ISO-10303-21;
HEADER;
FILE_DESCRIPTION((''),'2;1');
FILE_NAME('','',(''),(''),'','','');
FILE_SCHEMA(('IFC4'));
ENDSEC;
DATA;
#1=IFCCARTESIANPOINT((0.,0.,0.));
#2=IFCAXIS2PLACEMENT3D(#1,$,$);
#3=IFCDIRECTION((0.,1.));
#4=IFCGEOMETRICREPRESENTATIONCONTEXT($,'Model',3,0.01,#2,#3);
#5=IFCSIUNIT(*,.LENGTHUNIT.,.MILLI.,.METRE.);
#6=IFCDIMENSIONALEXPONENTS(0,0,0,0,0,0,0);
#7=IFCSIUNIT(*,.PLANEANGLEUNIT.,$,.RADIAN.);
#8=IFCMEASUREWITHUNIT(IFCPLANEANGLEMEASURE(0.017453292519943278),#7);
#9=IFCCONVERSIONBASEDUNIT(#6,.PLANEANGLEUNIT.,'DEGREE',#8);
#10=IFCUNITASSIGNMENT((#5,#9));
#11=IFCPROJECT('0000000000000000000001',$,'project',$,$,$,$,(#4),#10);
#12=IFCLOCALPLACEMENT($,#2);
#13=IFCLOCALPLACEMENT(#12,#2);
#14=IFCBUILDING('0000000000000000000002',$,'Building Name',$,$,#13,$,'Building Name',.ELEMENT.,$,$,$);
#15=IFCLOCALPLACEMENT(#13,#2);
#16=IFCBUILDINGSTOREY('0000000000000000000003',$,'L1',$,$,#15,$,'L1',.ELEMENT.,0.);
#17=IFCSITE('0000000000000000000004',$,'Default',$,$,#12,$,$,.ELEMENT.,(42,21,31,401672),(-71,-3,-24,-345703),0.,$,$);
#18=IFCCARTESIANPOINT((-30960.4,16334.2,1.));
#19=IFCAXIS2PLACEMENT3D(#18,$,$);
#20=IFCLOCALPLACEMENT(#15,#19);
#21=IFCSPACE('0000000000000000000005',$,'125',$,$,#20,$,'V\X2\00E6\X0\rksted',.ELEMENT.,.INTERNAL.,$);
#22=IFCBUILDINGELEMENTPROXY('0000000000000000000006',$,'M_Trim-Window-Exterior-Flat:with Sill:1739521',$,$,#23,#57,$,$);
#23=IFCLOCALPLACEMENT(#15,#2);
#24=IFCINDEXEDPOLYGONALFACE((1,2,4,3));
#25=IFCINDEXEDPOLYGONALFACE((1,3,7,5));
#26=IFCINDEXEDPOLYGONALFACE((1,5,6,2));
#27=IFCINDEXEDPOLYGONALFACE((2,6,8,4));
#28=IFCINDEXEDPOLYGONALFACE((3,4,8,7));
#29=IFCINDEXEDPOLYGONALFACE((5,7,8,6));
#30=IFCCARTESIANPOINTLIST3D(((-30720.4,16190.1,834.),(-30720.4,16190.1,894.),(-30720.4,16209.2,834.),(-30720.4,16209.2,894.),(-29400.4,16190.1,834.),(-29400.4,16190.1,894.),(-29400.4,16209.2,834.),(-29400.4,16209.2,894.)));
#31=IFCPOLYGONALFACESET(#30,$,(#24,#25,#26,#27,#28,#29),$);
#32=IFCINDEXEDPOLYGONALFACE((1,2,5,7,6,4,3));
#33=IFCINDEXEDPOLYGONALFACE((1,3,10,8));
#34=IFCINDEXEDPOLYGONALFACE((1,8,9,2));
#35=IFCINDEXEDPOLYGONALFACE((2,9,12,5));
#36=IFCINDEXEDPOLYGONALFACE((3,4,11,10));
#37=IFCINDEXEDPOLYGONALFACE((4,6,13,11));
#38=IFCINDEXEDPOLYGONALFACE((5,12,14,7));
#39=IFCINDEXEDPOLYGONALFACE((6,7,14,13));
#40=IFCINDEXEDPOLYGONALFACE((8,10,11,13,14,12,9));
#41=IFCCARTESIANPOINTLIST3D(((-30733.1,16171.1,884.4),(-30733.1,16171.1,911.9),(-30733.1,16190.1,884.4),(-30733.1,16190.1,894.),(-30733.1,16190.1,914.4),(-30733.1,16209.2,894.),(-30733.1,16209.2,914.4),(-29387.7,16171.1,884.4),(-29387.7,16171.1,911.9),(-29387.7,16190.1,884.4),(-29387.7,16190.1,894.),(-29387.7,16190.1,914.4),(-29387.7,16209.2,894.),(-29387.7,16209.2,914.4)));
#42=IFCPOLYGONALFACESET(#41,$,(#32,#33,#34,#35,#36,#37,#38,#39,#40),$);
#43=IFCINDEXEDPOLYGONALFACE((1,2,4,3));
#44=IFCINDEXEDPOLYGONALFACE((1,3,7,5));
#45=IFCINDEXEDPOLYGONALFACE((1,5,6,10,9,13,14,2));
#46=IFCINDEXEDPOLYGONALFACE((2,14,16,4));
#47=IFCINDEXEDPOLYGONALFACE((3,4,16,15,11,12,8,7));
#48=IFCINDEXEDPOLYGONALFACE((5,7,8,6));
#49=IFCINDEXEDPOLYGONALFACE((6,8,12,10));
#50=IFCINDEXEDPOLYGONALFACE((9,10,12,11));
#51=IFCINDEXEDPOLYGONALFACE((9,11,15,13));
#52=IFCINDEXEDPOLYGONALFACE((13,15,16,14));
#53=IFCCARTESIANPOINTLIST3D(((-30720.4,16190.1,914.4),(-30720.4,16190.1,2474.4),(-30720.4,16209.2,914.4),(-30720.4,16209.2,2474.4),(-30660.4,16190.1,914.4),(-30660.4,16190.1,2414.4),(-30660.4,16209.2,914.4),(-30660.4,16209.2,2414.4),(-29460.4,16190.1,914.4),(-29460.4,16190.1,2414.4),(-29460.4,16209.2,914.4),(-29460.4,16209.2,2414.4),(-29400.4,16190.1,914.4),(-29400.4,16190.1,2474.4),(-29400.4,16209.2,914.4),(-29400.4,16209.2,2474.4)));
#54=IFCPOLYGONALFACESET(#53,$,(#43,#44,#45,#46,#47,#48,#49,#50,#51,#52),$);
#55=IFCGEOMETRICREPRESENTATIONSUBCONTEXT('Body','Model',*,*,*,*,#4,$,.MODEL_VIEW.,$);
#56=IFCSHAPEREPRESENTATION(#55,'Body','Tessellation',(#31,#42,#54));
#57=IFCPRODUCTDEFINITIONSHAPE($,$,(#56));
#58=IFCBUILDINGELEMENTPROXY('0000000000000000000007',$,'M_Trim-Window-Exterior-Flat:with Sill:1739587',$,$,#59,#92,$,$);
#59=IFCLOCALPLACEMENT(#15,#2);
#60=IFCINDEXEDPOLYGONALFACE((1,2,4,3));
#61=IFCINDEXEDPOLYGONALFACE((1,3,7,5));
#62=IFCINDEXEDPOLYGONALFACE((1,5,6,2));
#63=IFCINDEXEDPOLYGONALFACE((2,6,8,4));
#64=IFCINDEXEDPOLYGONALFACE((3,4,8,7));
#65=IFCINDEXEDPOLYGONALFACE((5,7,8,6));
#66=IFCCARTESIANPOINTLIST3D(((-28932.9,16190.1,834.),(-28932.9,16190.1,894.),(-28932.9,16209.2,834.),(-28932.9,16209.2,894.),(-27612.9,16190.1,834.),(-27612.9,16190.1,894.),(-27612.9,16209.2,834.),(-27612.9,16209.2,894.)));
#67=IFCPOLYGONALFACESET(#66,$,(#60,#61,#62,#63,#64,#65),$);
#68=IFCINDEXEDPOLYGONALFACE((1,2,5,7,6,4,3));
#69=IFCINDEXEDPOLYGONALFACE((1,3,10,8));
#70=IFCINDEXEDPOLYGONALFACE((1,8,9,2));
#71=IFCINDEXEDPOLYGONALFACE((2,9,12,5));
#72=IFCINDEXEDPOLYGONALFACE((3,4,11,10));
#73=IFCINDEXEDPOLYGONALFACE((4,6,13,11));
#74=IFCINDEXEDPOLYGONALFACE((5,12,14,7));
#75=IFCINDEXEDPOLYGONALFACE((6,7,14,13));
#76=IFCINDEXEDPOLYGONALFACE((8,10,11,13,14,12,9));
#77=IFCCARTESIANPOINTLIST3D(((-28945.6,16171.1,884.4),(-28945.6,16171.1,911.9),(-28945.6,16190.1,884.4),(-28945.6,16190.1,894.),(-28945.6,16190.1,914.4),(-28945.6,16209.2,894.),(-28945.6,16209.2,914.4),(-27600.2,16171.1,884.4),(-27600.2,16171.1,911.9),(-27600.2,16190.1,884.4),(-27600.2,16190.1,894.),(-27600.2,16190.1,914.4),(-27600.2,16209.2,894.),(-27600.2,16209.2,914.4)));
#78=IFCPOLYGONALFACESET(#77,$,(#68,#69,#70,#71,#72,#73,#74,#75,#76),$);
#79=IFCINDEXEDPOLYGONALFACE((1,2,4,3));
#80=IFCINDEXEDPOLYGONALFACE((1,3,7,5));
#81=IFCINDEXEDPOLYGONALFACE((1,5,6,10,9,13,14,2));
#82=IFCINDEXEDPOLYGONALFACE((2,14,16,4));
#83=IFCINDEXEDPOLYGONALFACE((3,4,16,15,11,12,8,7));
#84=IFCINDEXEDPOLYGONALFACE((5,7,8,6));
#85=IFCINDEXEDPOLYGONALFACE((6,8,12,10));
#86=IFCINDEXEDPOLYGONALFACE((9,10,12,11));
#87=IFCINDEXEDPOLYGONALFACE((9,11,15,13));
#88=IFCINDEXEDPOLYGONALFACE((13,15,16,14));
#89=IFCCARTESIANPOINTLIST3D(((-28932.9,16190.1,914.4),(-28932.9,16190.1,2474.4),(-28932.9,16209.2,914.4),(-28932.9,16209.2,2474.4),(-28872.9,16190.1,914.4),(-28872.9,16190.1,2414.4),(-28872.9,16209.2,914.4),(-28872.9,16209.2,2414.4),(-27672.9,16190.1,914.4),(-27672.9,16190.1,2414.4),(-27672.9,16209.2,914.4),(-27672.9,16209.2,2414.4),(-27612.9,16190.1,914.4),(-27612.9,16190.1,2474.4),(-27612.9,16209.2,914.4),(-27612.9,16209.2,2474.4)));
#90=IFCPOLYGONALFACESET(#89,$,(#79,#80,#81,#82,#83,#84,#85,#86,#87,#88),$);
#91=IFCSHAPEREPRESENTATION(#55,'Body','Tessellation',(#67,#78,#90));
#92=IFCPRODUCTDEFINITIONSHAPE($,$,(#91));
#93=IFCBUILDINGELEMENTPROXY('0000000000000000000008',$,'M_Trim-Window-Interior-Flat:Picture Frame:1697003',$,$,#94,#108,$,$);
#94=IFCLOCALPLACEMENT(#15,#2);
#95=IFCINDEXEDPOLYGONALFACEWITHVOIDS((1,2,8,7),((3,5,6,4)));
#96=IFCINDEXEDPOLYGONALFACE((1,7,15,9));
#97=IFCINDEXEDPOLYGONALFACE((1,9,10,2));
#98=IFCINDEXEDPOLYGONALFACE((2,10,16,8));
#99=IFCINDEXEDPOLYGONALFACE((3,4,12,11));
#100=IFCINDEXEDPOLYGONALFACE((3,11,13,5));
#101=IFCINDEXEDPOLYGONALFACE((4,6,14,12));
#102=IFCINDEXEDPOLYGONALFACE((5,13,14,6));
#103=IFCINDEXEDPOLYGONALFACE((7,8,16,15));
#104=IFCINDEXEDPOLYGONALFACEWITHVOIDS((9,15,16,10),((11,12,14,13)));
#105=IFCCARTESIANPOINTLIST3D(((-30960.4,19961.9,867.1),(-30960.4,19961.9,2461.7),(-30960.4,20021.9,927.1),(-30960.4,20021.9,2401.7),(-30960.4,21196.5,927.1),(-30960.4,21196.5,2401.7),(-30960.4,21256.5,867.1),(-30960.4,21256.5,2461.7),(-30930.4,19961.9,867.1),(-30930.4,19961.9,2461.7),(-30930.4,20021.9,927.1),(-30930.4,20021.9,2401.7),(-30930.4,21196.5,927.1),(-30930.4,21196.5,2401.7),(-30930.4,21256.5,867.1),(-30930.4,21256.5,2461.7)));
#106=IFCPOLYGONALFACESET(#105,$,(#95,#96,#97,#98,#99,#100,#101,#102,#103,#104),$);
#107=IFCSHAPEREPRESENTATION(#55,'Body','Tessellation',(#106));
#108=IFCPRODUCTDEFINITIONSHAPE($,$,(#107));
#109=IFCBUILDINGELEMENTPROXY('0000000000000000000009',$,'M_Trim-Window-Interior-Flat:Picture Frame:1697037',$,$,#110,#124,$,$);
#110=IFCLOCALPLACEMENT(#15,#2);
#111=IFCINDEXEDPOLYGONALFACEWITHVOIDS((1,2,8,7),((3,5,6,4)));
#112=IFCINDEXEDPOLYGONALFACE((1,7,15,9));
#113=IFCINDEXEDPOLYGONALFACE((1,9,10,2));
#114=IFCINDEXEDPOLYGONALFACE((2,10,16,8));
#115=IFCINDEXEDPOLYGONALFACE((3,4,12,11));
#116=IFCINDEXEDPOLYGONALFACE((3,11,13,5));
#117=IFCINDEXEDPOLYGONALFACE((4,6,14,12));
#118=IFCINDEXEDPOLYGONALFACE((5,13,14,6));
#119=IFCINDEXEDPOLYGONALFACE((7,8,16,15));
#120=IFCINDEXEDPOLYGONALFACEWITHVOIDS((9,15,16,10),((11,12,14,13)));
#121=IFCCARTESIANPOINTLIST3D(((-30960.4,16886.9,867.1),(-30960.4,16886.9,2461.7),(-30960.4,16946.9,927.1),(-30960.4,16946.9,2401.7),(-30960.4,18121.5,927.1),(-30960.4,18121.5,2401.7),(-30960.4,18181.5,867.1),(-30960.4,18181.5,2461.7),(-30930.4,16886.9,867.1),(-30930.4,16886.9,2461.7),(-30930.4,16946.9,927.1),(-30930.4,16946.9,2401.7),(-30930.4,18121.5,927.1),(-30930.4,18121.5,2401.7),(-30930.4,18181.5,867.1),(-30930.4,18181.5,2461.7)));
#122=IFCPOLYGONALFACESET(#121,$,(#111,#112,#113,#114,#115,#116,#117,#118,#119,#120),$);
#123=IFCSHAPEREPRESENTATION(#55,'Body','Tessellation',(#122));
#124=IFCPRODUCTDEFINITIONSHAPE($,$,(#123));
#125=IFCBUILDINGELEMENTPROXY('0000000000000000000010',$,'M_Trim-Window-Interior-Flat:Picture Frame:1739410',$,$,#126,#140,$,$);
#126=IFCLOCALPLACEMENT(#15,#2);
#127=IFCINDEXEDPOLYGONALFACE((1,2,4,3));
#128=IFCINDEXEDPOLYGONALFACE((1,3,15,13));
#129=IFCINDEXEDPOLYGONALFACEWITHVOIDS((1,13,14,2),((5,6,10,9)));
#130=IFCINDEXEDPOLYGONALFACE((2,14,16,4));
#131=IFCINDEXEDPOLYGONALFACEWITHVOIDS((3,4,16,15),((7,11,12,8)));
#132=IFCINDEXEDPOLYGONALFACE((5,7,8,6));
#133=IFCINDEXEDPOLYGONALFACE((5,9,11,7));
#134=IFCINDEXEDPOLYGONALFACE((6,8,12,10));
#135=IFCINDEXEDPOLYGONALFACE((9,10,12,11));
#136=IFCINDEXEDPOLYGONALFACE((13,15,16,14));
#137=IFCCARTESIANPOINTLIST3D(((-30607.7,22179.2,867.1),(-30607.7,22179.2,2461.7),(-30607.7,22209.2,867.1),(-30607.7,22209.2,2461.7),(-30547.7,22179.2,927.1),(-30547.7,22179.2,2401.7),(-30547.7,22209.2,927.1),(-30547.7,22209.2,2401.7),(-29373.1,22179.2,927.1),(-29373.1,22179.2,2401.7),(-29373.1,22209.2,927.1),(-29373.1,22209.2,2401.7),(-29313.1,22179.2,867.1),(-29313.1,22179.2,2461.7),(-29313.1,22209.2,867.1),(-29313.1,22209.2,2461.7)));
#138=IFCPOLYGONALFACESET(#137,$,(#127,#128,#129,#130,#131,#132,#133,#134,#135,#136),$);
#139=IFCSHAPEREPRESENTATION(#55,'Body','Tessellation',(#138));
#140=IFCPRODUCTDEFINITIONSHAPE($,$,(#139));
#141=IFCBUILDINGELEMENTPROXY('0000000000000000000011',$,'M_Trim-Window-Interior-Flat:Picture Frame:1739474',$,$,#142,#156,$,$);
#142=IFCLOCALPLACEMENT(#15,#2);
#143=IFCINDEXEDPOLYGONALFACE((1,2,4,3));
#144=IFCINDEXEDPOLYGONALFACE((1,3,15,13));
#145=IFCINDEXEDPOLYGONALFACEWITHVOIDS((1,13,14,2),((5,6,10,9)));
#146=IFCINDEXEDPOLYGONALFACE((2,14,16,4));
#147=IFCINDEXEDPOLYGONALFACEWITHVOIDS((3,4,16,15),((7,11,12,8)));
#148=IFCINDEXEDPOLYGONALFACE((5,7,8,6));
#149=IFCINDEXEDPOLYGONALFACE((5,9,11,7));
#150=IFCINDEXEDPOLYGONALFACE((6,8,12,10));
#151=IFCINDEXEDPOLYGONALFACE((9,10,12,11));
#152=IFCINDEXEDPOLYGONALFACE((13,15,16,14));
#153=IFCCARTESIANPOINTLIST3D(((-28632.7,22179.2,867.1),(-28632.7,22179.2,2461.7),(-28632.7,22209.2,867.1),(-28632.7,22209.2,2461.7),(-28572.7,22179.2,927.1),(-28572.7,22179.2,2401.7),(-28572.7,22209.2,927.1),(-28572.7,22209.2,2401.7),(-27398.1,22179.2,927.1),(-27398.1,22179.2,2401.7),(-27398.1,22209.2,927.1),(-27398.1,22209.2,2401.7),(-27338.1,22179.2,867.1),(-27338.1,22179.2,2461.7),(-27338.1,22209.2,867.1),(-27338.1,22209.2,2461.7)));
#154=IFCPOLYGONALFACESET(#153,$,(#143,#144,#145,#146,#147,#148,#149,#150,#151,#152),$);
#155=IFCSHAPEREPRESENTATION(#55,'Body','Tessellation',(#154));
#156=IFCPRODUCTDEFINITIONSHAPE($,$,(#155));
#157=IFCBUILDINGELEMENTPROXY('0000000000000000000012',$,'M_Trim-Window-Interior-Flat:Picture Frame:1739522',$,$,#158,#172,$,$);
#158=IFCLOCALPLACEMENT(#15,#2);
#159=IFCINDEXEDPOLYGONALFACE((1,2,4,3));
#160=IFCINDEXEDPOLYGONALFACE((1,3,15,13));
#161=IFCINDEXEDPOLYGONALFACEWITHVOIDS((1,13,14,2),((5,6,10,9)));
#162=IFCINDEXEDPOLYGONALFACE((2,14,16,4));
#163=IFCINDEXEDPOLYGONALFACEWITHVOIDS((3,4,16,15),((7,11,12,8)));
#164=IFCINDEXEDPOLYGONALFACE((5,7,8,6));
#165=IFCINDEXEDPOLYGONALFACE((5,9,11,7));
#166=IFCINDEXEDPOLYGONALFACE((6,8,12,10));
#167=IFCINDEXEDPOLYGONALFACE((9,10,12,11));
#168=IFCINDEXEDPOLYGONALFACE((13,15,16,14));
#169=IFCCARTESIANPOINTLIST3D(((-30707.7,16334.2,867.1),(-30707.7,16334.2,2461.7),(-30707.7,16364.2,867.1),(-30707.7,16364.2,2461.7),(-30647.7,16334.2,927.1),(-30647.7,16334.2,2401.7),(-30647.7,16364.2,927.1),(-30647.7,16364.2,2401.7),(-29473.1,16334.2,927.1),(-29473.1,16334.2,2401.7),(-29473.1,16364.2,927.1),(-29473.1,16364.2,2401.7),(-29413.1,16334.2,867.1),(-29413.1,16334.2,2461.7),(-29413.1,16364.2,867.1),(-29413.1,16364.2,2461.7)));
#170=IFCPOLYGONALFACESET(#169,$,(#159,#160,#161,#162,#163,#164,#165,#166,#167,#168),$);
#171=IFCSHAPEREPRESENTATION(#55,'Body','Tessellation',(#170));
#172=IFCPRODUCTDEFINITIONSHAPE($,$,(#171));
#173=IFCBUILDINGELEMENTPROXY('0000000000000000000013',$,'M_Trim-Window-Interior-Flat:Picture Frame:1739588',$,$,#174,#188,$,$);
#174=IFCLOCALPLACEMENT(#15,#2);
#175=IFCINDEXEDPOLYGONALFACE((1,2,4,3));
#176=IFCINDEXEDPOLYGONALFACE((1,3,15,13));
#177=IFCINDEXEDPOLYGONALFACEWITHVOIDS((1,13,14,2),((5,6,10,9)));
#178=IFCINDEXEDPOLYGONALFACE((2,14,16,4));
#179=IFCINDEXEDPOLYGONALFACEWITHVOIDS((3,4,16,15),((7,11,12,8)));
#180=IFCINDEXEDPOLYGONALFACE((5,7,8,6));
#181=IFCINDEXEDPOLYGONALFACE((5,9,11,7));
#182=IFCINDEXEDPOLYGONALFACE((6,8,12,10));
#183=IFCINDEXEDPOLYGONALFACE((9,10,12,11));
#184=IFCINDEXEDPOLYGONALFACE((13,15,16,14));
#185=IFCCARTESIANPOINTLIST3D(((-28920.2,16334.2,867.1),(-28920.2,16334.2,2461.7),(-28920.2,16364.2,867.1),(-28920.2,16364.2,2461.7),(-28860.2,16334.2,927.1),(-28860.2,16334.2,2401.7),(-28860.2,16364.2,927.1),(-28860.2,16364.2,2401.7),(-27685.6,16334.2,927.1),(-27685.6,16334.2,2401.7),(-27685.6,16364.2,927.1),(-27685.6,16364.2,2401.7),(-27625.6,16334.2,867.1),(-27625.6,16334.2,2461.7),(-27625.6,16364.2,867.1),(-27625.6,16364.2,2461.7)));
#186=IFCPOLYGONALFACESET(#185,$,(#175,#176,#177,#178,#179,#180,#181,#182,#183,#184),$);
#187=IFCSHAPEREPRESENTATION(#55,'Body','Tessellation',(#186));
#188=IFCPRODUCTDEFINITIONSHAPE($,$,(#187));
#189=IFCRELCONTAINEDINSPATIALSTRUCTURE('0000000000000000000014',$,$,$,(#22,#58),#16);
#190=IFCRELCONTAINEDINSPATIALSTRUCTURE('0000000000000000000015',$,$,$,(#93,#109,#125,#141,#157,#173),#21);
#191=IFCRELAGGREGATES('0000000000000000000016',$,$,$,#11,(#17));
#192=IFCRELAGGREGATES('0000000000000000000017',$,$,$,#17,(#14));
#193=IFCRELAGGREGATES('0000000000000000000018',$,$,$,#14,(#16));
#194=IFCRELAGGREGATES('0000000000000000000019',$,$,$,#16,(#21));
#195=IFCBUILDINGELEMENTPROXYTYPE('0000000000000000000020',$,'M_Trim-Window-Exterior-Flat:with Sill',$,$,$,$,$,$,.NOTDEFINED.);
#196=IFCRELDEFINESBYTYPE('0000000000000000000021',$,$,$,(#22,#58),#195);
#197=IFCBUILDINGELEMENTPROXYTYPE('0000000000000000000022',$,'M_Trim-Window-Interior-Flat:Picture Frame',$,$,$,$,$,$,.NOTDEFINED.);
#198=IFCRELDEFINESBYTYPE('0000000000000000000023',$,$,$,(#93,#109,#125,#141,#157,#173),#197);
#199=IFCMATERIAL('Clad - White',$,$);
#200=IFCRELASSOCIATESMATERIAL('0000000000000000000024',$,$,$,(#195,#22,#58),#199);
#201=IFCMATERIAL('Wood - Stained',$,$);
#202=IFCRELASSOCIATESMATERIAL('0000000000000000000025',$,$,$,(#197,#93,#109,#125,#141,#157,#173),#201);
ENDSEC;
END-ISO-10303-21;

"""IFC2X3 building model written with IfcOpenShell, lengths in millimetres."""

from ifc_helpers import new_model, entity, si_unit, converted_unit, direction, frame, frame_2d, origin, place, context, subcontext, project, spatial, polyline, rectangle, outline, extrude, source, transform, mapped, material, type_object, type_shapes, element, save


model = new_model("IFC2X3")

# Units and contexts
model_context = context("Model", 3, precision=0.01, world=origin(), true_north=direction((0.0, 1.0)))
body_context = subcontext(model_context, "Body", "Model", "MODEL_VIEW")
ifc_project = project(units=[si_unit("LENGTHUNIT", "METRE", prefix="MILLI"), converted_unit("PLANEANGLEUNIT", "DEGREE", entity("IfcPlaneAngleMeasure", 0.017453292519943278), si_unit("PLANEANGLEUNIT", "RADIAN"), dimensions=[0, 0, 0, 0, 0, 0, 0])], contexts=[model_context])

# Site, building, storey
site_placement = place(None, origin())
site = spatial("IfcSite", under=ifc_project, at=site_placement, Name="Default", CompositionType="ELEMENT", RefLatitude=(42, 21, 31, 401672), RefLongitude=(-71, -3, -24, -345703), RefElevation=0.0)
building_placement = place(site_placement, origin())
building = spatial("IfcBuilding", under=site, at=building_placement, Name="Building Name", LongName="Building Name", CompositionType="ELEMENT")
storey_placement = place(building_placement, origin())
storey = spatial("IfcBuildingStorey", under=building, at=storey_placement, Name="L1", LongName="L1", CompositionType="ELEMENT", Elevation=0.0)

# Shared definitions
ifc_material_1 = material(Name="Wood - Stained")

# Building element proxies
ifc_material_2 = material(Name="Clad - White")
building_element_proxy_type_1 = type_object("IfcBuildingElementProxyType", Name="M_Trim-Window-Exterior-Flat:with Sill", PredefinedType="NOTDEFINED", material=ifc_material_2)
shared_shape_1 = source(origin(), body_context, "Body", "SweptSolid", [
    extrude(rectangle(XDim=1320.0, YDim=60.0, at=frame_2d((0.0, 0.0), x_axis=(1.0, 0.0))), frame((0.0, -1550.4, 0.0), z_axis=(0.0, 0.0, 1.0), x_axis=(-1.0, 0.0, 0.0)), (0.0, 0.0, 1.0), 19.0),
    extrude(outline(polyline([(-19.0, -15.2), (0.0, -15.2), (0.0, -5.7), (19.0, -5.7), (19.0, 14.8), (0.0, 14.8), (-19.0, 12.3), (-19.0, -15.2)])), frame((-672.7, -1514.8, 19.0), z_axis=(1.0, 0.0, 0.0), x_axis=(0.0, 0.0, -1.0)), (0.0, 0.0, 1.0), 1345.4),
    extrude(outline(polyline([(-795.0, -660.0), (765.0, -660.0), (765.0, -600.0), (-735.0, -600.0), (-735.0, 600.0), (765.0, 600.0), (765.0, 660.0), (-795.0, 660.0), (-795.0, -660.0)])), frame((0.0, -735.0, 0.0), z_axis=(0.0, 0.0, 1.0), x_axis=(0.0, -1.0, 0.0)), (0.0, 0.0, 1.0), 19.0),
])
type_shapes(building_element_proxy_type_1, [shared_shape_1])
for number, where, z_axis, x_axis, name in (
    (1, (-30060.4, 16209.2, 2414.4), (0.0, -1.0, 0.0), (1.0, 0.0, 0.0), "M_Trim-Window-Exterior-Flat:with Sill:1739521"),
    (2, (-28272.9, 16209.2, 2414.4), (0.0, -1.0, 0.0), (1.0, 0.0, 0.0), "M_Trim-Window-Exterior-Flat:with Sill:1739587"),
):
    element("IfcBuildingElementProxy", number, at=place(storey_placement, frame(where, z_axis=z_axis, x_axis=x_axis)), inside=storey, type_object=building_element_proxy_type_1, material=ifc_material_2, Name=name, context=body_context, shape_type="MappedRepresentation", body=[
        mapped(shared_shape_1, transform((0.0, 0.0, 0.0), scale=1.0)),
    ])

# Shared definitions
space_placement = place(storey_placement, frame((-30960.4, 16334.2, 1.0)))
space = spatial("IfcSpace", under=storey, at=space_placement, Name="125", LongName="Værksted", CompositionType="ELEMENT", InteriorOrExteriorSpace="INTERNAL")

# Building element proxies
building_element_proxy_type_2 = type_object("IfcBuildingElementProxyType", Name="M_Trim-Window-Interior-Flat:Picture Frame", PredefinedType="NOTDEFINED", material=ifc_material_1)
shared_shape_2 = source(origin(), body_context, "Body", "SweptSolid", [
    extrude(outline(polyline([(-647.3, -797.3), (647.3, -797.3), (647.3, 797.3), (-647.3, 797.3), (-647.3, -797.3)]), holes=[polyline([(-587.3, -737.3), (-587.3, 737.3), (587.3, 737.3), (587.3, -737.3), (-587.3, -737.3)])]), frame((0.0, -750.0, 0.0), z_axis=(0.0, 0.0, 1.0), x_axis=(-1.0, 0.0, 0.0)), (0.0, 0.0, 1.0), 30.0),
])
type_shapes(building_element_proxy_type_2, [shared_shape_2])
for number, where, z_axis, x_axis, name in (
    (3, (0.0, 4275.0, 2413.4), (1.0, 0.0, 0.0), (0.0, 1.0, 0.0), "M_Trim-Window-Interior-Flat:Picture Frame:1697003"),
    (4, (0.0, 1200.0, 2413.4), (1.0, 0.0, 0.0), (0.0, 1.0, 0.0), "M_Trim-Window-Interior-Flat:Picture Frame:1697037"),
    (5, (1000.0, 5875.0, 2413.4), (0.0, -1.0, 0.0), (1.0, 0.0, 0.0), "M_Trim-Window-Interior-Flat:Picture Frame:1739410"),
    (6, (2975.0, 5875.0, 2413.4), (0.0, -1.0, 0.0), (1.0, 0.0, 0.0), "M_Trim-Window-Interior-Flat:Picture Frame:1739474"),
    (7, (900.0, 0.0, 2413.4), (0.0, 1.0, 0.0), (-1.0, 0.0, 0.0), "M_Trim-Window-Interior-Flat:Picture Frame:1739522"),
    (8, (2687.5, 0.0, 2413.4), (0.0, 1.0, 0.0), (-1.0, 0.0, 0.0), "M_Trim-Window-Interior-Flat:Picture Frame:1739588"),
):
    element("IfcBuildingElementProxy", number, at=place(space_placement, frame(where, z_axis=z_axis, x_axis=x_axis)), inside=space, type_object=building_element_proxy_type_2, material=ifc_material_1, Name=name, context=body_context, shape_type="MappedRepresentation", body=[
        mapped(shared_shape_2, transform((0.0, 0.0, 0.0), scale=1.0)),
    ])

save(model, "model.ifc")
